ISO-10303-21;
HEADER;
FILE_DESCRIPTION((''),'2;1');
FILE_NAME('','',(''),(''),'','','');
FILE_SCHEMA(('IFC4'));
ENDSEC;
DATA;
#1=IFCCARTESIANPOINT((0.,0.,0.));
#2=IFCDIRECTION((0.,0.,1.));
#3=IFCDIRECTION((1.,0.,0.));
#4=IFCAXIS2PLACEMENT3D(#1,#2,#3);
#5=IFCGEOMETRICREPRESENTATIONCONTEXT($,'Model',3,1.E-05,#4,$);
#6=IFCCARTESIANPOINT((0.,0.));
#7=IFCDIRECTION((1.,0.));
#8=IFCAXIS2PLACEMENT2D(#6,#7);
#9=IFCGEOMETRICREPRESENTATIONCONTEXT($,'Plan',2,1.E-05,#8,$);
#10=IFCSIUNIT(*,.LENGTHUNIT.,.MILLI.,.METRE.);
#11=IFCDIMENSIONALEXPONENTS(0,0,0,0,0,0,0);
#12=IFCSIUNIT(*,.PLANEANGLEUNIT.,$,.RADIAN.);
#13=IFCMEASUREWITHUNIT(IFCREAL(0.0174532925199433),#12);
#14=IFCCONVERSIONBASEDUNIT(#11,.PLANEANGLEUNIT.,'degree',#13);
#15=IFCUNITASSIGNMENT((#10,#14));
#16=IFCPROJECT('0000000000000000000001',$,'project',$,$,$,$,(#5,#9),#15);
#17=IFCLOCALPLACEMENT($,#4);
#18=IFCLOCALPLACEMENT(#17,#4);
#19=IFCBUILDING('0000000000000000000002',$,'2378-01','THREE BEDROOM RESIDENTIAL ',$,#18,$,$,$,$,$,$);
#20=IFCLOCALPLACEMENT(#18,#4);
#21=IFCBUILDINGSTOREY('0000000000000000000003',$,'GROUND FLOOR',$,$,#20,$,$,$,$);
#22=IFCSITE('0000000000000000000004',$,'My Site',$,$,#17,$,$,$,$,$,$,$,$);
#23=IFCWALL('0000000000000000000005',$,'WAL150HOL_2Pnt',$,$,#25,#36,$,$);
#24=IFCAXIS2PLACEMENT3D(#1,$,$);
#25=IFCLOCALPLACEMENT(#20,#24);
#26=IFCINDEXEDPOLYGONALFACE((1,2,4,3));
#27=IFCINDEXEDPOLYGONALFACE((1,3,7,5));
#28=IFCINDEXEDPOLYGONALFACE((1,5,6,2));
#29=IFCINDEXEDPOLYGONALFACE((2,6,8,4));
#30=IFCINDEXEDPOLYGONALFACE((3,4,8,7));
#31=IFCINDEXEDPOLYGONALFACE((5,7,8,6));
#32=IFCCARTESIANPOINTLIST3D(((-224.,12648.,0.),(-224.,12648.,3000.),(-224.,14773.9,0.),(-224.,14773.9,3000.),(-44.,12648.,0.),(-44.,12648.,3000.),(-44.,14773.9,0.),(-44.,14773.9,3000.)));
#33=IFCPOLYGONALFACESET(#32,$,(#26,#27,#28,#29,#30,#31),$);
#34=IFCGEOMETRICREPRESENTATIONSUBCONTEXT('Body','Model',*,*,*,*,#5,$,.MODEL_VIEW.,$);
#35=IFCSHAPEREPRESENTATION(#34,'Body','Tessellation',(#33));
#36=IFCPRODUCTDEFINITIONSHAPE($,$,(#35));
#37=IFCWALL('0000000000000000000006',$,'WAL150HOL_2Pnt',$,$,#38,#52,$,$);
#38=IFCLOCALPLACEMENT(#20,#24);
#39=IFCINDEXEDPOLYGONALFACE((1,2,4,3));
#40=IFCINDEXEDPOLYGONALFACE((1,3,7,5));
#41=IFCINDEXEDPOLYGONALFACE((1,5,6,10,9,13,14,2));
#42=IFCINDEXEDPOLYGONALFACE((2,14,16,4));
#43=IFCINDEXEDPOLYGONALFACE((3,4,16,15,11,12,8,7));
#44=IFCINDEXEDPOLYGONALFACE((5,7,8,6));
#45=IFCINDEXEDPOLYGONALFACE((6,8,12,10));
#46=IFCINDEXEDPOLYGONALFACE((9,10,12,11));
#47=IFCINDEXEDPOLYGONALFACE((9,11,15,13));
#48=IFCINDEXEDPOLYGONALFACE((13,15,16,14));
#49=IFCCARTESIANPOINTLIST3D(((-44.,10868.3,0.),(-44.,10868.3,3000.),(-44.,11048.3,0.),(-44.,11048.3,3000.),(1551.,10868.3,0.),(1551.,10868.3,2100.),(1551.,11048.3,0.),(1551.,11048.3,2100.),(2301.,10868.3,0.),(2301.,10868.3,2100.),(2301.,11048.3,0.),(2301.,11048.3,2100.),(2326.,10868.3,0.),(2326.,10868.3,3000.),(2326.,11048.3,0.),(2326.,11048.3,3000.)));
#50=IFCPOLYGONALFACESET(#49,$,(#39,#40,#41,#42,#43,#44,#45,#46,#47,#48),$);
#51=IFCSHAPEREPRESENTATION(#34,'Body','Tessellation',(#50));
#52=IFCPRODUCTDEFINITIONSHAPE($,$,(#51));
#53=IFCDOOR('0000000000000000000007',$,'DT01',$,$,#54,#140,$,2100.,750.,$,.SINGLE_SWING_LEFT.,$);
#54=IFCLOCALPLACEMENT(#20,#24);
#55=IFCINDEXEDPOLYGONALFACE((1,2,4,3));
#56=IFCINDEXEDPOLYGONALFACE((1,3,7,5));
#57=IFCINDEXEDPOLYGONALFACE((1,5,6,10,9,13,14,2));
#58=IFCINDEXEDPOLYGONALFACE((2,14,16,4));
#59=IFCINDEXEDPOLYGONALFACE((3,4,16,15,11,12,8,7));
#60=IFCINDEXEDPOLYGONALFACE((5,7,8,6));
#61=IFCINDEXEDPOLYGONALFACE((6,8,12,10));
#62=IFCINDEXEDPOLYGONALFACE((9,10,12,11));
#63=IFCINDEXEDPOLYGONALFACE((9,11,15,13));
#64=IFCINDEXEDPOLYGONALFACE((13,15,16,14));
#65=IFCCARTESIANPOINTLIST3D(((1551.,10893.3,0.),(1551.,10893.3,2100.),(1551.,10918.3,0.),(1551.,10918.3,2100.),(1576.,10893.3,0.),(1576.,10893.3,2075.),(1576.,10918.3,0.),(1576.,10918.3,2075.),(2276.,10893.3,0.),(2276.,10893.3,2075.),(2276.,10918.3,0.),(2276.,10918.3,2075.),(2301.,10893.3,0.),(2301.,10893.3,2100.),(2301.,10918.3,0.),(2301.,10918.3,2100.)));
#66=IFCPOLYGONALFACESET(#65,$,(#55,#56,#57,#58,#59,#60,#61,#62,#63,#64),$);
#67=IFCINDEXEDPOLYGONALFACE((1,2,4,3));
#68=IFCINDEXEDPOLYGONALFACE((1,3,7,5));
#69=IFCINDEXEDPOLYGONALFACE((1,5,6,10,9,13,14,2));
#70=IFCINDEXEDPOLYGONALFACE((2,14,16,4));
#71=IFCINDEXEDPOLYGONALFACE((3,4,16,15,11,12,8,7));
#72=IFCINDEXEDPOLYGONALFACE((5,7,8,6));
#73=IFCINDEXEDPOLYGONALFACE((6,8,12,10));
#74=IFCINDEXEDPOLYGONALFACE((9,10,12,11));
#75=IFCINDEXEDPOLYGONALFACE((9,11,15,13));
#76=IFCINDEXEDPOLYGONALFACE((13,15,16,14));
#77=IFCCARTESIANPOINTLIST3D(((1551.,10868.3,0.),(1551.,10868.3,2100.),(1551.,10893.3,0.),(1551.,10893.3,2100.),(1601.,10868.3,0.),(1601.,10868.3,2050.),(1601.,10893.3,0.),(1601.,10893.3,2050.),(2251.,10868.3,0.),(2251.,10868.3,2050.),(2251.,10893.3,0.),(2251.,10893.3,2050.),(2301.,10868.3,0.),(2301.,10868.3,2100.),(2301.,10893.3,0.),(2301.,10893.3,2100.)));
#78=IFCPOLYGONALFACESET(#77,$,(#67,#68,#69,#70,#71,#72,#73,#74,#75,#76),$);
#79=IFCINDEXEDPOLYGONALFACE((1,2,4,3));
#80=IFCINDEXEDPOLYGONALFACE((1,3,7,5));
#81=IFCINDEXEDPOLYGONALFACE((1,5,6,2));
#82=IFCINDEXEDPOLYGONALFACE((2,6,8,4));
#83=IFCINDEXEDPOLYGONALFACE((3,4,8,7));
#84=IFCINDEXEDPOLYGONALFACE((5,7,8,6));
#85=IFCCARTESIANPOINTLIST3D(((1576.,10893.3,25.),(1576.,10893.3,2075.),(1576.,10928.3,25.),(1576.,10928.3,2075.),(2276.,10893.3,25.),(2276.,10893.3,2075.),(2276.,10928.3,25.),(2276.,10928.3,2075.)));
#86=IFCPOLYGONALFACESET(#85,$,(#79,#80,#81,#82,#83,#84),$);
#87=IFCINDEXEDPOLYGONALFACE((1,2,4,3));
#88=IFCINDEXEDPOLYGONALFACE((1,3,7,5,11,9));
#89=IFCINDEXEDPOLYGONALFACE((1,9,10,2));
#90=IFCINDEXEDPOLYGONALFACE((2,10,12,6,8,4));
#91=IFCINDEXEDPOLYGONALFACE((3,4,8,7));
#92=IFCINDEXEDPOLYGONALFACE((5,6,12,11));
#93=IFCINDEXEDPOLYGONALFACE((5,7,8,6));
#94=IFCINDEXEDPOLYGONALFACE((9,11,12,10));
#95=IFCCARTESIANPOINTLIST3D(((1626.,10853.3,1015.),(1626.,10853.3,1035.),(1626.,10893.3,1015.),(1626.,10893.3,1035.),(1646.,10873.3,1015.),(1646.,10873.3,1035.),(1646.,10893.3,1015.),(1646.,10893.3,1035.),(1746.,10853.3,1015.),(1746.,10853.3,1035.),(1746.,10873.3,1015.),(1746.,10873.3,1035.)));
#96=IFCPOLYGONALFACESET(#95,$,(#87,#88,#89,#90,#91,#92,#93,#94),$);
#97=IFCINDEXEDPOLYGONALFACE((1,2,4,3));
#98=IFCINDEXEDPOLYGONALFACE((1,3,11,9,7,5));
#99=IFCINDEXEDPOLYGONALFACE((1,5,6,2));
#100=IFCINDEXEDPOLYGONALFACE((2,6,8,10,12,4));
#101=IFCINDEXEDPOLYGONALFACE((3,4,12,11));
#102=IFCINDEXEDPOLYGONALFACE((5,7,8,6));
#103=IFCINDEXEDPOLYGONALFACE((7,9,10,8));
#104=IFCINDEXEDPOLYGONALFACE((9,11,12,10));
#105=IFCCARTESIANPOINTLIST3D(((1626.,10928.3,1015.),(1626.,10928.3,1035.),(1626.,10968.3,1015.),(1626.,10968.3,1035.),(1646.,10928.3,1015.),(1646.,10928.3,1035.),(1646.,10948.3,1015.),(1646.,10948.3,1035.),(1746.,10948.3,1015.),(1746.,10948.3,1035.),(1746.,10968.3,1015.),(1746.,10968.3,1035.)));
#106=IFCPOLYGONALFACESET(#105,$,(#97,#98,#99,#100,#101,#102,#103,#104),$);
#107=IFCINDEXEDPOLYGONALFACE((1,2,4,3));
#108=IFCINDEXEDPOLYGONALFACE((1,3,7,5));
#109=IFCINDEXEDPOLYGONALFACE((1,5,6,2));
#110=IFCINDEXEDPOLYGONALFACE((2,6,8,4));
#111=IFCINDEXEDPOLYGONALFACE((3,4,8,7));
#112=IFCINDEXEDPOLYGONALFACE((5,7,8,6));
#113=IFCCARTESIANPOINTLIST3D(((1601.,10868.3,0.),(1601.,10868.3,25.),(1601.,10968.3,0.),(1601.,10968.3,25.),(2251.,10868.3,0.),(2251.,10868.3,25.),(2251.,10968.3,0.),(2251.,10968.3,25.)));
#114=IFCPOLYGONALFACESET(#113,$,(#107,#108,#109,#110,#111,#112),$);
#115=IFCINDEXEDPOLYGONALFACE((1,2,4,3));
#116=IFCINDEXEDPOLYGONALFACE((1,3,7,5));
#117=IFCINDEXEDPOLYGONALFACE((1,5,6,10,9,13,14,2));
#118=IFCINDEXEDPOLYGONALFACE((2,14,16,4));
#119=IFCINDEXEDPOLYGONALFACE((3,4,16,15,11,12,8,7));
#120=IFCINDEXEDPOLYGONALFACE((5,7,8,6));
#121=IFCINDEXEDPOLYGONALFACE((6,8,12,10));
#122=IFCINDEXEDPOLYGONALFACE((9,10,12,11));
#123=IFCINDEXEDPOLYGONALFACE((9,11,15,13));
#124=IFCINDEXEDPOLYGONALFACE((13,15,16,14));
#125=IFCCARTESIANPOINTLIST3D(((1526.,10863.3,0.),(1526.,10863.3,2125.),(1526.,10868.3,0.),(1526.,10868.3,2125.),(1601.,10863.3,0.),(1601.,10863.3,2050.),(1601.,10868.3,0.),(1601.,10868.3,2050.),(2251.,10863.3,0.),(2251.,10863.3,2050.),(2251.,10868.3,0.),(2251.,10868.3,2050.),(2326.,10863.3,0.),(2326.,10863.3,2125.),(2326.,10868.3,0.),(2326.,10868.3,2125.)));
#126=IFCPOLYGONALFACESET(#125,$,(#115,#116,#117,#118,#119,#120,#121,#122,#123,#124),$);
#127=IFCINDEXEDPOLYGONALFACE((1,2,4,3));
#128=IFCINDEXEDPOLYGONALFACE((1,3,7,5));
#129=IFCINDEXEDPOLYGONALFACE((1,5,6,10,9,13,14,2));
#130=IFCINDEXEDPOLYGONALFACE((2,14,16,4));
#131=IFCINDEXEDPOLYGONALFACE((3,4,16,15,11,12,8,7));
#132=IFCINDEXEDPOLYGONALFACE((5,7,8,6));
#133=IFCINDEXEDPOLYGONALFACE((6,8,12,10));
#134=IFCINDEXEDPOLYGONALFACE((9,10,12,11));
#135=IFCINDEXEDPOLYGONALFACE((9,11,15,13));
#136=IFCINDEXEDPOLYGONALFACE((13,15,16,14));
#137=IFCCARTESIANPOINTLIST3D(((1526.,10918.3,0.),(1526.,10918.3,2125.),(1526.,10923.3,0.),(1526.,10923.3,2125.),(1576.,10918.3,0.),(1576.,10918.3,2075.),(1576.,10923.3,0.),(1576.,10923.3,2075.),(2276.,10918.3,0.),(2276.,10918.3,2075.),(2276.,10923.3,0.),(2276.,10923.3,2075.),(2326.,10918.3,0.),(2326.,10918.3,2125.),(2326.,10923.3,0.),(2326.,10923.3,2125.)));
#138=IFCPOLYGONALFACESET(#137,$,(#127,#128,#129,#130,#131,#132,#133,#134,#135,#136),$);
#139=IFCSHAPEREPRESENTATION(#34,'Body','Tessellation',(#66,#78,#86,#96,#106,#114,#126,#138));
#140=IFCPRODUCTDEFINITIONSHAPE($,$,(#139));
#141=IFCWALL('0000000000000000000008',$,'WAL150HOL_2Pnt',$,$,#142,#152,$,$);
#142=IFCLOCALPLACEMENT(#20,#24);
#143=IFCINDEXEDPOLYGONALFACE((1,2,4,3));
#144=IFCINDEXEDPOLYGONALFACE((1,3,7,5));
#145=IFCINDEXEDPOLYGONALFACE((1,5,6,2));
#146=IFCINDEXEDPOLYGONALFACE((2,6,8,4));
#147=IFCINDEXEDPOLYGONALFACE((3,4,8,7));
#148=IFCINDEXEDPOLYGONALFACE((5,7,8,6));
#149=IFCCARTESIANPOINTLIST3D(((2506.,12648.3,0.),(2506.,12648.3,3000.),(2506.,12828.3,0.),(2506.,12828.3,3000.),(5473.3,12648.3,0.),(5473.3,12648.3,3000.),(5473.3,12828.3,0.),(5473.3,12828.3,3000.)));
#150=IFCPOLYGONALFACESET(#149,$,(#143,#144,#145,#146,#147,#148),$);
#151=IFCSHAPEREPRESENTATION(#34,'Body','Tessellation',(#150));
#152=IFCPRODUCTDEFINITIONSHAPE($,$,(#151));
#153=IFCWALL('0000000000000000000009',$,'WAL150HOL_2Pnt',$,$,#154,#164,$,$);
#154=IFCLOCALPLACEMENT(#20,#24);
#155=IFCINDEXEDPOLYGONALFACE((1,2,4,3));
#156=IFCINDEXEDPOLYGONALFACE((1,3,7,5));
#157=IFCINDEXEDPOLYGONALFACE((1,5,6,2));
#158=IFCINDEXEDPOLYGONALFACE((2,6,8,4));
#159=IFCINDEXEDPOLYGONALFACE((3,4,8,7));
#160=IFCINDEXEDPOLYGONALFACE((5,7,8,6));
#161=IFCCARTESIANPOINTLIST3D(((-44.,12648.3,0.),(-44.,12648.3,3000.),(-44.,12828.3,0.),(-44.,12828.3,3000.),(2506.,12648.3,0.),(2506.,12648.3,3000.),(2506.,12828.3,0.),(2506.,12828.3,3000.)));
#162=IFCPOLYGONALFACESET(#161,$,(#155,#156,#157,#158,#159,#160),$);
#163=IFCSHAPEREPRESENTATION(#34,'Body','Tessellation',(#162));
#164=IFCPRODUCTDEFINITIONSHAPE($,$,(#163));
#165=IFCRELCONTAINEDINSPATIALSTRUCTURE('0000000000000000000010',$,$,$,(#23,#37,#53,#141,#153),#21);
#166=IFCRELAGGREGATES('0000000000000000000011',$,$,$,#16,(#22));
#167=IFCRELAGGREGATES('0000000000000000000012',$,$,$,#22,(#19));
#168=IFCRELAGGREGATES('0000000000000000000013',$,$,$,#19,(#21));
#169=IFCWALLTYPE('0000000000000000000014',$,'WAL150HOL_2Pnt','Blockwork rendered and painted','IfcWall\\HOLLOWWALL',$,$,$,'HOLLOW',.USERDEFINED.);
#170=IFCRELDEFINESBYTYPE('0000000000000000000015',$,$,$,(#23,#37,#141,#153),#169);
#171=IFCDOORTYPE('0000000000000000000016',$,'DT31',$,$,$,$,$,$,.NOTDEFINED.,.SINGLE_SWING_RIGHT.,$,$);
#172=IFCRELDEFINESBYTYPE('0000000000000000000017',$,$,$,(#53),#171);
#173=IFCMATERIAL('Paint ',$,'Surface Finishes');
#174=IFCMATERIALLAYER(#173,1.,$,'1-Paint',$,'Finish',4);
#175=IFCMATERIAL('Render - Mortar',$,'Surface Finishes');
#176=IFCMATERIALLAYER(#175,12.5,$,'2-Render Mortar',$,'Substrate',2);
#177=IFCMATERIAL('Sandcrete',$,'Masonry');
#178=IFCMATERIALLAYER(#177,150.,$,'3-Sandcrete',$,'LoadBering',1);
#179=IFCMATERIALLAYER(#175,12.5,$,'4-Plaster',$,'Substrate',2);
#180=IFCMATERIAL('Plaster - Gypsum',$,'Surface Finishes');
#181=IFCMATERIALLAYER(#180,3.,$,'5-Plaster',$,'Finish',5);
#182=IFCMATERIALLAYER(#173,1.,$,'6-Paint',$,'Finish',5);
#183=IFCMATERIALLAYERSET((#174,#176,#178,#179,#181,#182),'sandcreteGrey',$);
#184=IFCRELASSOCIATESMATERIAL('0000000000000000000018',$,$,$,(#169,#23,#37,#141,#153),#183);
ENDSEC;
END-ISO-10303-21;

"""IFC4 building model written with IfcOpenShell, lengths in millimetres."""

from ifc_helpers import new_model, entity, si_unit, converted_unit, frame, origin_with_axes, origin_2d_with_axis, place, context, subcontext, project, spatial, line, indexed_curve, outline, extrude, shape, source, transform, mapped, material, layer, layer_set, layer_usage, type_object, type_shapes, element, fill, save


model = new_model("IFC4")

# Units and contexts
model_context = context("Model", 3, precision=1e-05, world=origin_with_axes())
plan_context = context("Plan", 2, precision=1e-05, world=origin_2d_with_axis())
body_context_1 = subcontext(model_context, "Body", "Model", "MODEL_VIEW")
body_context_2 = subcontext(plan_context, "Body", "Plan", "PLAN_VIEW")
ifc_project = project(units=[si_unit("LENGTHUNIT", "METRE", prefix="MILLI"), converted_unit("PLANEANGLEUNIT", "degree", entity("IfcReal", 0.0174532925199433), si_unit("PLANEANGLEUNIT", "RADIAN"), dimensions=[0, 0, 0, 0, 0, 0, 0])], contexts=[model_context, plan_context])

# Site, building, storey
site_placement = place(None, origin_with_axes())
site = spatial("IfcSite", under=ifc_project, at=site_placement, Name="My Site")
building_placement = place(site_placement, origin_with_axes())
building = spatial("IfcBuilding", under=site, at=building_placement, Name="2378-01", Description="THREE BEDROOM RESIDENTIAL ")
storey_placement = place(building_placement, origin_with_axes())
storey = spatial("IfcBuildingStorey", under=building, at=storey_placement, Name="GROUND FLOOR")

# Wall
ifc_material_1 = material(Name="Paint ", Category="Surface Finishes")
ifc_layer_1 = layer(ifc_material_1, 1.0, Name="1-Paint", Category="Finish", Priority=4)
ifc_material_2 = material(Name="Render - Mortar", Category="Surface Finishes")
ifc_layer_2 = layer(ifc_material_2, 12.5, Name="2-Render Mortar", Category="Substrate", Priority=2)
ifc_material_3 = material(Name="Sandcrete", Category="Masonry")
ifc_layer_3 = layer(ifc_material_3, 150.0, Name="3-Sandcrete", Category="LoadBering", Priority=1)
ifc_layer_4 = layer(ifc_material_2, 12.5, Name="4-Plaster", Category="Substrate", Priority=2)
ifc_material_4 = material(Name="Plaster - Gypsum", Category="Surface Finishes")
ifc_layer_5 = layer(ifc_material_4, 3.0, Name="5-Plaster", Category="Finish", Priority=5)
ifc_layer_6 = layer(ifc_material_1, 1.0, Name="6-Paint", Category="Finish", Priority=5)
ifc_layer_set_1 = layer_set([ifc_layer_1, ifc_layer_2, ifc_layer_3, ifc_layer_4, ifc_layer_5, ifc_layer_6], Name="sandcreteGrey")
ifc_layer_usage_1 = layer_usage(ifc_layer_set_1, "AXIS2", "POSITIVE", 0.0)
wall_type_1 = type_object("IfcWallType", Name="WAL150HOL_2Pnt", Description="Blockwork rendered and painted", ApplicableOccurrence="IfcWall\\HOLLOWWALL", ElementType="HOLLOW", PredefinedType="USERDEFINED", material=ifc_layer_set_1)
wall_1_placement = place(storey_placement, frame((-224.0, 14773.9, 0.0), z_axis=(0.0, 0.0, 1.0), x_axis=(0.0, -1.0, 0.0)))
element("IfcWall", 1, at=wall_1_placement, inside=storey, type_object=wall_type_1, material=ifc_layer_usage_1, Name="WAL150HOL_2Pnt", context=body_context_1, shape_type="SweptSolid", body=[
    extrude(outline(indexed_curve([(0.0, 0.0), (0.0, 180.0), (2125.9, 180.0), (2125.9, 0.0), (0.0, 0.0)], self_intersect=False)), origin_with_axes(), (0.0, 0.0, 1.0), 3000.0),
])

# Wall, opening, door
ifc_layer_usage_2 = layer_usage(ifc_layer_set_1, "AXIS2", "POSITIVE", 0.0)
wall_2_placement = place(storey_placement, frame((-44.0, 10868.3, 0.0), z_axis=(0.0, 0.0, 1.0), x_axis=(1.0, -0.000002, 0.0)))
wall_2 = element("IfcWall", 2, at=wall_2_placement, inside=storey, type_object=wall_type_1, material=ifc_layer_usage_2, Name="WAL150HOL_2Pnt", context=body_context_1, shape_type="SweptSolid", body=[
    extrude(outline(indexed_curve([(0.0, 0.0), (0.0, 180.0), (2370.0, 180.0), (2370.0, 0.0), (0.0, 0.0)], self_intersect=False)), origin_with_axes(), (0.0, 0.0, 1.0), 3000.0),
])
shared_shape_1 = source(origin_with_axes(), body_context_1, "Body", "SweptSolid", [
    extrude(outline(indexed_curve([(0.0, 0.0), (750.0, 0.0), (750.0, 2100.0), (0.0, 2100.0)], segments=[line(1, 2, 3, 4, 1)])), frame((0.0, -600.0, 0.0), z_axis=(0.0, -1.0, 0.0), x_axis=(1.0, 0.0, 0.0)), (0.0, 0.0, -1.0), 1200.0),
])
opening_1_placement = place(wall_2_placement, frame((1595.0, 0.0, 0.0), z_axis=(0.0, 0.0, 1.0), x_axis=(1.0, 0.0, 0.0)))
opening_1 = element("IfcOpeningElement", 3, at=opening_1_placement, cuts=wall_2, PredefinedType="OPENING", context=body_context_1, shape_type="MappedRepresentation", body=[
    mapped(shared_shape_1, transform((0.0, 0.0, 0.0), x_axis=(1.0, 0.0, 0.0), y_axis=(0.0, 1.0, 0.0), z_axis=(0.0, 0.0, 1.0), scale=1.0)),
])
door_type_1 = type_object("IfcDoorType", Name="DT31", OperationType="SINGLE_SWING_RIGHT", PredefinedType="NOTDEFINED")
shared_shape_2 = source(origin_with_axes(), body_context_1, "Body", "SweptSolid", [
    extrude(outline(indexed_curve([(0.0, 0.0), (0.0, 2100.0), (750.0, 2100.0), (750.0, 0.0), (725.0, 0.0), (725.0, 2075.0), (25.0, 2075.0), (25.0, 0.0)], segments=[line(1, 2, 3, 4, 5, 6, 7, 8, 1)])), frame((0.0, 25.0, 0.0), z_axis=(0.0, -1.0, 0.0), x_axis=(1.0, 0.0, 0.0)), (0.0, 0.0, -1.0), 25.0),
    extrude(outline(indexed_curve([(0.0, 0.0), (0.0, 2100.0), (750.0, 2100.0), (750.0, 0.0), (700.0, 0.0), (700.0, 2050.0), (50.0, 2050.0), (50.0, 0.0)], segments=[line(1, 2, 3, 4, 5, 6, 7, 8, 1)])), frame((0.0, 0.0, 0.0), z_axis=(0.0, -1.0, 0.0), x_axis=(1.0, 0.0, 0.0)), (0.0, 0.0, -1.0), 25.0),
    extrude(outline(indexed_curve([(0.0, 0.0), (700.0, 0.0), (700.0, 35.0), (0.0, 35.0)], segments=[line(1, 2, 3, 4, 1)])), frame((25.0, 25.0, 25.0), z_axis=(0.0, 0.0, 1.0), x_axis=(1.0, 0.0, 0.0)), (0.0, 0.0, 1.0), 2050.0),
    extrude(outline(indexed_curve([(0.0, 0.0), (0.0, -40.0), (120.0, -40.0), (120.0, -20.0), (20.0, -20.0), (20.0, 0.0)], segments=[line(1, 2, 3, 4, 5, 6, 1)])), frame((75.0, 25.0, 1015.0), z_axis=(0.0, 0.0, 1.0), x_axis=(1.0, 0.0, 0.0)), (0.0, 0.0, 1.0), 20.0),
    extrude(outline(indexed_curve([(0.0, 0.0), (0.0, 40.0), (120.0, 40.0), (120.0, 20.0), (20.0, 20.0), (20.0, 0.0)], segments=[line(1, 2, 3, 4, 5, 6, 1)])), frame((75.0, 60.0, 1015.0), z_axis=(0.0, 0.0, 1.0), x_axis=(1.0, 0.0, 0.0)), (0.0, 0.0, 1.0), 20.0),
    extrude(outline(indexed_curve([(0.0, 0.0), (650.0, 0.0), (650.0, 100.0), (0.0, 100.0)], segments=[line(1, 2, 3, 4, 1)])), frame((50.0, 0.0, 0.0), z_axis=(0.0, 0.0, 1.0), x_axis=(1.0, 0.0, 0.0)), (0.0, 0.0, 1.0), 25.0),
    extrude(outline(indexed_curve([(0.0, 0.0), (0.0, 2125.0), (800.0, 2125.0), (800.0, 0.0), (725.0, 0.0), (725.0, 2050.0), (75.0, 2050.0), (75.0, 0.0)], segments=[line(1, 2, 3, 4, 5, 6, 7, 8, 1)])), frame((-25.0, -5.0, 0.0), z_axis=(0.0, -1.0, 0.0), x_axis=(1.0, 0.0, 0.0)), (0.0, 0.0, -1.0), 5.0),
    extrude(outline(indexed_curve([(0.0, 0.0), (0.0, 2125.0), (800.0, 2125.0), (800.0, 0.0), (750.0, 0.0), (750.0, 2075.0), (50.0, 2075.0), (50.0, 0.0)], segments=[line(1, 2, 3, 4, 5, 6, 7, 8, 1)])), frame((-25.0, 50.0, 0.0), z_axis=(0.0, -1.0, 0.0), x_axis=(1.0, 0.0, 0.0)), (0.0, 0.0, -1.0), 5.0),
])
shared_shape_3 = source(origin_with_axes(), body_context_2, "Body", "Curve2D", [
    entity("IfcIndexedPolyCurve", entity("IfcCartesianPointList2D", [[0.0, 0.0], [0.0, 50.0], [25.0, 50.0], [25.0, 25.0], [50.0, 25.0], [50.0, 0.0]]), [entity("IfcLineIndex", [1, 2, 3, 4, 5, 6, 1])]),
    entity("IfcIndexedPolyCurve", entity("IfcCartesianPointList2D", [[750.0, 0.0], [750.0, 50.0], [725.0, 50.0], [725.0, 25.0], [700.0, 25.0], [700.0, 0.0]]), [entity("IfcLineIndex", [1, 2, 3, 4, 5, 6, 1])]),
    entity("IfcTrimmedCurve", entity("IfcEllipse", entity("IfcAxis2Placement2D", entity("IfcCartesianPoint", [690.0, 50.0]), entity("IfcDirection", [1.0, 0.0])), 665.0, 700.0), [entity("IfcCartesianPoint", [690.0, 750.0])], [entity("IfcCartesianPoint", [25.0, 50.0])], True, "CARTESIAN"),
    entity("IfcIndexedPolyCurve", entity("IfcCartesianPointList2D", [[725.0, 50.0], [690.0, 50.0], [690.0, 750.0], [725.0, 750.0]]), [entity("IfcLineIndex", [1, 2, 3, 4, 1])]),
])
type_shapes(door_type_1, [shared_shape_2, shared_shape_3])
door_1_placement = place(opening_1_placement, origin_with_axes())
door_1 = element("IfcDoor", 4, at=door_1_placement, inside=storey, type_object=door_type_1, Name="DT01", OperationType="SINGLE_SWING_LEFT", OverallHeight=2100.0, OverallWidth=750.0, shapes=[
    shape(body_context_1, "Body", "MappedRepresentation", [mapped(shared_shape_2, transform((0.0, 0.0, 0.0), x_axis=(1.0, 0.0, 0.0), y_axis=(0.0, 1.0, 0.0), z_axis=(0.0, 0.0, 1.0), scale=1.0))]),
    shape(body_context_2, "Body", "MappedRepresentation", [mapped(shared_shape_3, transform((0.0, 0.0, 0.0), x_axis=(1.0, 0.0, 0.0), y_axis=(0.0, 1.0, 0.0), z_axis=(0.0, 0.0, 1.0), scale=1.0))]),
])
fill(opening_1, door_1)

# Walls
ifc_layer_usage_3 = layer_usage(ifc_layer_set_1, "AXIS2", "POSITIVE", 0.0)
wall_3_placement = place(storey_placement, frame((5473.3, 12828.3, 0.0), z_axis=(0.0, 0.0, 1.0), x_axis=(-1.0, 0.0, 0.0)))
element("IfcWall", 5, at=wall_3_placement, inside=storey, type_object=wall_type_1, material=ifc_layer_usage_3, Name="WAL150HOL_2Pnt", context=body_context_1, shape_type="SweptSolid", body=[
    extrude(outline(indexed_curve([(0.0, 0.0), (0.0, 180.0), (2967.3, 180.0), (2967.3, 0.0), (0.0, 0.0)], self_intersect=False)), origin_with_axes(), (0.0, 0.0, 1.0), 3000.0),
])
ifc_layer_usage_4 = layer_usage(ifc_layer_set_1, "AXIS2", "POSITIVE", 0.0)
wall_4_placement = place(storey_placement, frame((2506.0, 12828.3, 0.0), z_axis=(0.0, 0.0, 1.0), x_axis=(-1.0, 0.0, 0.0)))
element("IfcWall", 6, at=wall_4_placement, inside=storey, type_object=wall_type_1, material=ifc_layer_usage_4, Name="WAL150HOL_2Pnt", context=body_context_1, shape_type="SweptSolid", body=[
    extrude(outline(indexed_curve([(0.0, 0.0), (0.0, 180.0), (2550.0, 180.0), (2550.0, 0.0), (0.0, 0.0)], self_intersect=False)), origin_with_axes(), (0.0, 0.0, 1.0), 3000.0),
])

save(model, "model.ifc")
